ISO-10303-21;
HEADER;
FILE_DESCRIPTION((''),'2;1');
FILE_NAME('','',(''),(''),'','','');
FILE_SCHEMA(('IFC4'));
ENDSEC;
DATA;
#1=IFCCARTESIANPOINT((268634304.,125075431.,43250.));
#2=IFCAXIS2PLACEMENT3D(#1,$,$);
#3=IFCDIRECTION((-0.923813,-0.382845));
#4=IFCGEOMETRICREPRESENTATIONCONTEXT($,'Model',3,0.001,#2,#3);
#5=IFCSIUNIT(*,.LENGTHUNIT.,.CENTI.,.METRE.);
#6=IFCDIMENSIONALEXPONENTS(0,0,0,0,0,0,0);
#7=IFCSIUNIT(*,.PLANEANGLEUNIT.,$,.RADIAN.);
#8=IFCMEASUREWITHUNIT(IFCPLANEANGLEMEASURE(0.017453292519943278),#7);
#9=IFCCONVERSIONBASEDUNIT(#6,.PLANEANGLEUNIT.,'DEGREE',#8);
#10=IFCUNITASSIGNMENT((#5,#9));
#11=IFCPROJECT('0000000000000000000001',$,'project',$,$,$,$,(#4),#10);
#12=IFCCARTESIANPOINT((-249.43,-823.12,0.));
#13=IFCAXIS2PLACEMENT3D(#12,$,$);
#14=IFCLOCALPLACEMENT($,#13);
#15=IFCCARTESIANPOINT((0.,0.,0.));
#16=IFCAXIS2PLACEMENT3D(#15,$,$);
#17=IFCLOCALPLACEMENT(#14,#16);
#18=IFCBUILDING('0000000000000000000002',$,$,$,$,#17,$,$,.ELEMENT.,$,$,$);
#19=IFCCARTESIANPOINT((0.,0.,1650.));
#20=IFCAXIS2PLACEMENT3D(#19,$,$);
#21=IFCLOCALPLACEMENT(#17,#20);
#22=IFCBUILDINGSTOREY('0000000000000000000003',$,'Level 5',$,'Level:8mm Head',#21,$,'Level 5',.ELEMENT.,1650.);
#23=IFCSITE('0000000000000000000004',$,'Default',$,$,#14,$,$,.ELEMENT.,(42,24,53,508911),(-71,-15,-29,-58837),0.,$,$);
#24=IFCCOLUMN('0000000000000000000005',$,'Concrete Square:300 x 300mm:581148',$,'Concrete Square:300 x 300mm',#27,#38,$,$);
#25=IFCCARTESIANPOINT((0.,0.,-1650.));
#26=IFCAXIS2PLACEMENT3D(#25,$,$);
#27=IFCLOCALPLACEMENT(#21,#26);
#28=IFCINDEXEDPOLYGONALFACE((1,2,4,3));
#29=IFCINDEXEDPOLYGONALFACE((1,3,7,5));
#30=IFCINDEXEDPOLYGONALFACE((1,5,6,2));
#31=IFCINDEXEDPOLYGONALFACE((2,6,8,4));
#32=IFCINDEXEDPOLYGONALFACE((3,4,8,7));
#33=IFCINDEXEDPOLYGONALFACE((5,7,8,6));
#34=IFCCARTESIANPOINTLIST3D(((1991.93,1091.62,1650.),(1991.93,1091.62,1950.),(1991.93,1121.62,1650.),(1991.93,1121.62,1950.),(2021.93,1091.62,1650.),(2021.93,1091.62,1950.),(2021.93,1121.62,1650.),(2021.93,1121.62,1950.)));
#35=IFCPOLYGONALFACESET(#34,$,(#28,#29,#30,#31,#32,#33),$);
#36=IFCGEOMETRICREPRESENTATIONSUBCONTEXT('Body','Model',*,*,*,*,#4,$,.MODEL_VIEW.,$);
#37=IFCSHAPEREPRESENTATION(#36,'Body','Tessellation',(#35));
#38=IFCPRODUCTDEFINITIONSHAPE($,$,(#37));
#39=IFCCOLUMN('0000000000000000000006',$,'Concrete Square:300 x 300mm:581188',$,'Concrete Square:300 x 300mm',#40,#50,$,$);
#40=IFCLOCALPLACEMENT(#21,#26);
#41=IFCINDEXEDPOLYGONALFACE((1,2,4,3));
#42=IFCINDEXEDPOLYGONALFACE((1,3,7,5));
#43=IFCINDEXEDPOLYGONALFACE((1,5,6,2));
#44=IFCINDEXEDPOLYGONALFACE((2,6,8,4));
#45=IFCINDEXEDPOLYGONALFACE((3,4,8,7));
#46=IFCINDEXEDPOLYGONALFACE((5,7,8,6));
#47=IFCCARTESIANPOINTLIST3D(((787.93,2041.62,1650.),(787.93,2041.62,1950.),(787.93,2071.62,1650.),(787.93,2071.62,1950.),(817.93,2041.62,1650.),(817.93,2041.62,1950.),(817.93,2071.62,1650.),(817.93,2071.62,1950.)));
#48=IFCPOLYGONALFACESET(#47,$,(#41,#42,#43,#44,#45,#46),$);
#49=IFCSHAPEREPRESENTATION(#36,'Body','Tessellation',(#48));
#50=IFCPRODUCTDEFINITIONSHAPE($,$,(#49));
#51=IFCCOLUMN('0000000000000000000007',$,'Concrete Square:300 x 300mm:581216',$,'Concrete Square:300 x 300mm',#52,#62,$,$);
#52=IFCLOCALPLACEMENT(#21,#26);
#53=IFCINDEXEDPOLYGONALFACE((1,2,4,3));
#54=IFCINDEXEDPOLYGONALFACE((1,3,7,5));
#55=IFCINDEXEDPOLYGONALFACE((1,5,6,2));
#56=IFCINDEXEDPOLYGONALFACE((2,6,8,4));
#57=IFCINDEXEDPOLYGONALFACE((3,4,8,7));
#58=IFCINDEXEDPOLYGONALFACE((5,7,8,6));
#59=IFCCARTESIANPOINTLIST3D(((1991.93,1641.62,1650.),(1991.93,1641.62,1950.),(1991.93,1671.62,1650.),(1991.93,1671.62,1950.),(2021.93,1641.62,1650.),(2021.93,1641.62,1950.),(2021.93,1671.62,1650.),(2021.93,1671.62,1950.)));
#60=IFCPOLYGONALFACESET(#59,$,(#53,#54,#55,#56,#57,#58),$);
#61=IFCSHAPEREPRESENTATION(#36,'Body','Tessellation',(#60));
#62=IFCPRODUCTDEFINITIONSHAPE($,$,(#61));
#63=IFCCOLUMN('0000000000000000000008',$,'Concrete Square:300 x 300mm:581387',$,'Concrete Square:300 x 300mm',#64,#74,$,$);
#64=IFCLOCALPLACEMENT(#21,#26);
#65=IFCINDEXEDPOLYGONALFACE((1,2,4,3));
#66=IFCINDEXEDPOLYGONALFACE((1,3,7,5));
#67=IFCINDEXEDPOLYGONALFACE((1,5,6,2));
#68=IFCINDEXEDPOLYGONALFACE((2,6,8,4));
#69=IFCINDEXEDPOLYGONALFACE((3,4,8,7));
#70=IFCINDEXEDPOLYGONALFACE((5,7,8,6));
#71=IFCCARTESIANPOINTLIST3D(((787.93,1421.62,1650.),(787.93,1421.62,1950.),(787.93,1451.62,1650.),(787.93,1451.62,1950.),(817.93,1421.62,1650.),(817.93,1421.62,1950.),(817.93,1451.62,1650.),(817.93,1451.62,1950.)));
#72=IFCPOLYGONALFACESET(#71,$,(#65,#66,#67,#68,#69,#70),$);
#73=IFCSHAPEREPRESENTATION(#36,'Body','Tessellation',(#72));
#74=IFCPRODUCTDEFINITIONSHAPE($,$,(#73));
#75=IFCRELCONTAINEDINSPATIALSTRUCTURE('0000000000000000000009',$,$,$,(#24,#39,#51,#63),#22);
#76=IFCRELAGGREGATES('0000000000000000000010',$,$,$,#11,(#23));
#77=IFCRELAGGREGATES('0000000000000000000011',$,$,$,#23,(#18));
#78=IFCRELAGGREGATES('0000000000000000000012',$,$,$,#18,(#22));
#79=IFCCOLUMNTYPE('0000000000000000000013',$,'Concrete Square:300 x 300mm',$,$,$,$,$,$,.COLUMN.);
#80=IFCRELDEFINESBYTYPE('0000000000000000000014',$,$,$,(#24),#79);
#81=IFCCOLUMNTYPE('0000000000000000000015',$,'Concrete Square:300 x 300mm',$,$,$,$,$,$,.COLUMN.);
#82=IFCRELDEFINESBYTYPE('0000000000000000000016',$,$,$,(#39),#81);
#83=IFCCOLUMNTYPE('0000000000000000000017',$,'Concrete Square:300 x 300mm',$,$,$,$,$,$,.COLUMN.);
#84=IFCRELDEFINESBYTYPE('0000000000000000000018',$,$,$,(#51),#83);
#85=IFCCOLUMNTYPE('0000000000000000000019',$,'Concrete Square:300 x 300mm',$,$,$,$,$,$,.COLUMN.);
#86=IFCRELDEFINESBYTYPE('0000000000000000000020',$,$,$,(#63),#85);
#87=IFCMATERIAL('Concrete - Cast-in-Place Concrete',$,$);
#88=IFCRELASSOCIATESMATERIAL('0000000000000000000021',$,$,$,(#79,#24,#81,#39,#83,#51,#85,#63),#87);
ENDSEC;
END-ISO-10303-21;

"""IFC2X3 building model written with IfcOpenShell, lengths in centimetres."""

from ifc_helpers import new_model, entity, si_unit, converted_unit, direction, frame, frame_2d, origin, place, context, subcontext, project, spatial, rectangle, extrude, source, transform, mapped, material, type_object, type_shapes, element, save


model = new_model("IFC2X3")

# Units and contexts
model_context = context("Model", 3, precision=0.001, world=frame((268634304.0, 125075431.0, 43250.0)), true_north=direction((-0.923813, -0.382845)))
body_context = subcontext(model_context, "Body", "Model", "MODEL_VIEW")
ifc_project = project(units=[si_unit("LENGTHUNIT", "METRE", prefix="CENTI"), converted_unit("PLANEANGLEUNIT", "DEGREE", entity("IfcPlaneAngleMeasure", 0.017453292519943278), si_unit("PLANEANGLEUNIT", "RADIAN"), dimensions=[0, 0, 0, 0, 0, 0, 0])], contexts=[model_context])

# Site, building, storey
site_placement = place(None, frame((-249.43, -823.12, 0.0)))
site = spatial("IfcSite", under=ifc_project, at=site_placement, Name="Default", CompositionType="ELEMENT", RefLatitude=(42, 24, 53, 508911), RefLongitude=(-71, -15, -29, -58837), RefElevation=0.0)
building_placement = place(site_placement, origin())
building = spatial("IfcBuilding", under=site, at=building_placement, CompositionType="ELEMENT")
storey_placement = place(building_placement, frame((0.0, 0.0, 1650.0)))
storey = spatial("IfcBuildingStorey", under=building, at=storey_placement, Name="Level 5", ObjectType="Level:8mm Head", LongName="Level 5", CompositionType="ELEMENT", Elevation=1650.0)

# Columns
ifc_material_1 = material(Name="Concrete - Cast-in-Place Concrete")
column_type_1 = type_object("IfcColumnType", Name="Concrete Square:300 x 300mm", PredefinedType="COLUMN", material=ifc_material_1)
shared_shape_1 = source(origin(), body_context, "Body", "SweptSolid", [
    extrude(rectangle(XDim=30.0, YDim=30.0, at=frame_2d((0.0, 0.0), x_axis=(1.0, 0.0))), frame((2006.93, 1106.62, 1650.0), z_axis=(0.0, 0.0, 1.0), x_axis=(-1.0, 0.0, 0.0)), (0.0, 0.0, 1.0), 300.0),
])
type_shapes(column_type_1, [shared_shape_1])
column_1_placement = place(storey_placement, frame((0.0, 0.0, -1650.0)))
element("IfcColumn", 1, at=column_1_placement, inside=storey, type_object=column_type_1, material=ifc_material_1, Name="Concrete Square:300 x 300mm:581148", ObjectType="Concrete Square:300 x 300mm", context=body_context, shape_type="MappedRepresentation", body=[
    mapped(shared_shape_1, transform((0.0, 0.0, 0.0), scale=1.0)),
])
column_type_2 = type_object("IfcColumnType", Name="Concrete Square:300 x 300mm", PredefinedType="COLUMN", material=ifc_material_1)
shared_shape_2 = source(origin(), body_context, "Body", "SweptSolid", [
    extrude(rectangle(XDim=30.0, YDim=30.0, at=frame_2d((0.0, 0.0), x_axis=(1.0, 0.0))), frame((802.93, 2056.62, 1650.0), z_axis=(0.0, 0.0, 1.0), x_axis=(-1.0, 0.0, 0.0)), (0.0, 0.0, 1.0), 300.0),
])
type_shapes(column_type_2, [shared_shape_2])
column_2_placement = place(storey_placement, frame((0.0, 0.0, -1650.0)))
element("IfcColumn", 2, at=column_2_placement, inside=storey, type_object=column_type_2, material=ifc_material_1, Name="Concrete Square:300 x 300mm:581188", ObjectType="Concrete Square:300 x 300mm", context=body_context, shape_type="MappedRepresentation", body=[
    mapped(shared_shape_2, transform((0.0, 0.0, 0.0), scale=1.0)),
])
column_type_3 = type_object("IfcColumnType", Name="Concrete Square:300 x 300mm", PredefinedType="COLUMN", material=ifc_material_1)
shared_shape_3 = source(origin(), body_context, "Body", "SweptSolid", [
    extrude(rectangle(XDim=30.0, YDim=30.0, at=frame_2d((0.0, 0.0), x_axis=(1.0, 0.0))), frame((2006.93, 1656.62, 1650.0), z_axis=(0.0, 0.0, 1.0), x_axis=(-1.0, 0.0, 0.0)), (0.0, 0.0, 1.0), 300.0),
])
type_shapes(column_type_3, [shared_shape_3])
column_3_placement = place(storey_placement, frame((0.0, 0.0, -1650.0)))
element("IfcColumn", 3, at=column_3_placement, inside=storey, type_object=column_type_3, material=ifc_material_1, Name="Concrete Square:300 x 300mm:581216", ObjectType="Concrete Square:300 x 300mm", context=body_context, shape_type="MappedRepresentation", body=[
    mapped(shared_shape_3, transform((0.0, 0.0, 0.0), scale=1.0)),
])
column_type_4 = type_object("IfcColumnType", Name="Concrete Square:300 x 300mm", PredefinedType="COLUMN", material=ifc_material_1)
shared_shape_4 = source(origin(), body_context, "Body", "SweptSolid", [
    extrude(rectangle(XDim=30.0, YDim=30.0, at=frame_2d((0.0, 0.0), x_axis=(1.0, 0.0))), frame((802.93, 1436.62, 1650.0), z_axis=(0.0, 0.0, 1.0), x_axis=(-1.0, 0.0, 0.0)), (0.0, 0.0, 1.0), 300.0),
])
type_shapes(column_type_4, [shared_shape_4])
column_4_placement = place(storey_placement, frame((0.0, 0.0, -1650.0)))
element("IfcColumn", 4, at=column_4_placement, inside=storey, type_object=column_type_4, material=ifc_material_1, Name="Concrete Square:300 x 300mm:581387", ObjectType="Concrete Square:300 x 300mm", context=body_context, shape_type="MappedRepresentation", body=[
    mapped(shared_shape_4, transform((0.0, 0.0, 0.0), scale=1.0)),
])

save(model, "model.ifc")
